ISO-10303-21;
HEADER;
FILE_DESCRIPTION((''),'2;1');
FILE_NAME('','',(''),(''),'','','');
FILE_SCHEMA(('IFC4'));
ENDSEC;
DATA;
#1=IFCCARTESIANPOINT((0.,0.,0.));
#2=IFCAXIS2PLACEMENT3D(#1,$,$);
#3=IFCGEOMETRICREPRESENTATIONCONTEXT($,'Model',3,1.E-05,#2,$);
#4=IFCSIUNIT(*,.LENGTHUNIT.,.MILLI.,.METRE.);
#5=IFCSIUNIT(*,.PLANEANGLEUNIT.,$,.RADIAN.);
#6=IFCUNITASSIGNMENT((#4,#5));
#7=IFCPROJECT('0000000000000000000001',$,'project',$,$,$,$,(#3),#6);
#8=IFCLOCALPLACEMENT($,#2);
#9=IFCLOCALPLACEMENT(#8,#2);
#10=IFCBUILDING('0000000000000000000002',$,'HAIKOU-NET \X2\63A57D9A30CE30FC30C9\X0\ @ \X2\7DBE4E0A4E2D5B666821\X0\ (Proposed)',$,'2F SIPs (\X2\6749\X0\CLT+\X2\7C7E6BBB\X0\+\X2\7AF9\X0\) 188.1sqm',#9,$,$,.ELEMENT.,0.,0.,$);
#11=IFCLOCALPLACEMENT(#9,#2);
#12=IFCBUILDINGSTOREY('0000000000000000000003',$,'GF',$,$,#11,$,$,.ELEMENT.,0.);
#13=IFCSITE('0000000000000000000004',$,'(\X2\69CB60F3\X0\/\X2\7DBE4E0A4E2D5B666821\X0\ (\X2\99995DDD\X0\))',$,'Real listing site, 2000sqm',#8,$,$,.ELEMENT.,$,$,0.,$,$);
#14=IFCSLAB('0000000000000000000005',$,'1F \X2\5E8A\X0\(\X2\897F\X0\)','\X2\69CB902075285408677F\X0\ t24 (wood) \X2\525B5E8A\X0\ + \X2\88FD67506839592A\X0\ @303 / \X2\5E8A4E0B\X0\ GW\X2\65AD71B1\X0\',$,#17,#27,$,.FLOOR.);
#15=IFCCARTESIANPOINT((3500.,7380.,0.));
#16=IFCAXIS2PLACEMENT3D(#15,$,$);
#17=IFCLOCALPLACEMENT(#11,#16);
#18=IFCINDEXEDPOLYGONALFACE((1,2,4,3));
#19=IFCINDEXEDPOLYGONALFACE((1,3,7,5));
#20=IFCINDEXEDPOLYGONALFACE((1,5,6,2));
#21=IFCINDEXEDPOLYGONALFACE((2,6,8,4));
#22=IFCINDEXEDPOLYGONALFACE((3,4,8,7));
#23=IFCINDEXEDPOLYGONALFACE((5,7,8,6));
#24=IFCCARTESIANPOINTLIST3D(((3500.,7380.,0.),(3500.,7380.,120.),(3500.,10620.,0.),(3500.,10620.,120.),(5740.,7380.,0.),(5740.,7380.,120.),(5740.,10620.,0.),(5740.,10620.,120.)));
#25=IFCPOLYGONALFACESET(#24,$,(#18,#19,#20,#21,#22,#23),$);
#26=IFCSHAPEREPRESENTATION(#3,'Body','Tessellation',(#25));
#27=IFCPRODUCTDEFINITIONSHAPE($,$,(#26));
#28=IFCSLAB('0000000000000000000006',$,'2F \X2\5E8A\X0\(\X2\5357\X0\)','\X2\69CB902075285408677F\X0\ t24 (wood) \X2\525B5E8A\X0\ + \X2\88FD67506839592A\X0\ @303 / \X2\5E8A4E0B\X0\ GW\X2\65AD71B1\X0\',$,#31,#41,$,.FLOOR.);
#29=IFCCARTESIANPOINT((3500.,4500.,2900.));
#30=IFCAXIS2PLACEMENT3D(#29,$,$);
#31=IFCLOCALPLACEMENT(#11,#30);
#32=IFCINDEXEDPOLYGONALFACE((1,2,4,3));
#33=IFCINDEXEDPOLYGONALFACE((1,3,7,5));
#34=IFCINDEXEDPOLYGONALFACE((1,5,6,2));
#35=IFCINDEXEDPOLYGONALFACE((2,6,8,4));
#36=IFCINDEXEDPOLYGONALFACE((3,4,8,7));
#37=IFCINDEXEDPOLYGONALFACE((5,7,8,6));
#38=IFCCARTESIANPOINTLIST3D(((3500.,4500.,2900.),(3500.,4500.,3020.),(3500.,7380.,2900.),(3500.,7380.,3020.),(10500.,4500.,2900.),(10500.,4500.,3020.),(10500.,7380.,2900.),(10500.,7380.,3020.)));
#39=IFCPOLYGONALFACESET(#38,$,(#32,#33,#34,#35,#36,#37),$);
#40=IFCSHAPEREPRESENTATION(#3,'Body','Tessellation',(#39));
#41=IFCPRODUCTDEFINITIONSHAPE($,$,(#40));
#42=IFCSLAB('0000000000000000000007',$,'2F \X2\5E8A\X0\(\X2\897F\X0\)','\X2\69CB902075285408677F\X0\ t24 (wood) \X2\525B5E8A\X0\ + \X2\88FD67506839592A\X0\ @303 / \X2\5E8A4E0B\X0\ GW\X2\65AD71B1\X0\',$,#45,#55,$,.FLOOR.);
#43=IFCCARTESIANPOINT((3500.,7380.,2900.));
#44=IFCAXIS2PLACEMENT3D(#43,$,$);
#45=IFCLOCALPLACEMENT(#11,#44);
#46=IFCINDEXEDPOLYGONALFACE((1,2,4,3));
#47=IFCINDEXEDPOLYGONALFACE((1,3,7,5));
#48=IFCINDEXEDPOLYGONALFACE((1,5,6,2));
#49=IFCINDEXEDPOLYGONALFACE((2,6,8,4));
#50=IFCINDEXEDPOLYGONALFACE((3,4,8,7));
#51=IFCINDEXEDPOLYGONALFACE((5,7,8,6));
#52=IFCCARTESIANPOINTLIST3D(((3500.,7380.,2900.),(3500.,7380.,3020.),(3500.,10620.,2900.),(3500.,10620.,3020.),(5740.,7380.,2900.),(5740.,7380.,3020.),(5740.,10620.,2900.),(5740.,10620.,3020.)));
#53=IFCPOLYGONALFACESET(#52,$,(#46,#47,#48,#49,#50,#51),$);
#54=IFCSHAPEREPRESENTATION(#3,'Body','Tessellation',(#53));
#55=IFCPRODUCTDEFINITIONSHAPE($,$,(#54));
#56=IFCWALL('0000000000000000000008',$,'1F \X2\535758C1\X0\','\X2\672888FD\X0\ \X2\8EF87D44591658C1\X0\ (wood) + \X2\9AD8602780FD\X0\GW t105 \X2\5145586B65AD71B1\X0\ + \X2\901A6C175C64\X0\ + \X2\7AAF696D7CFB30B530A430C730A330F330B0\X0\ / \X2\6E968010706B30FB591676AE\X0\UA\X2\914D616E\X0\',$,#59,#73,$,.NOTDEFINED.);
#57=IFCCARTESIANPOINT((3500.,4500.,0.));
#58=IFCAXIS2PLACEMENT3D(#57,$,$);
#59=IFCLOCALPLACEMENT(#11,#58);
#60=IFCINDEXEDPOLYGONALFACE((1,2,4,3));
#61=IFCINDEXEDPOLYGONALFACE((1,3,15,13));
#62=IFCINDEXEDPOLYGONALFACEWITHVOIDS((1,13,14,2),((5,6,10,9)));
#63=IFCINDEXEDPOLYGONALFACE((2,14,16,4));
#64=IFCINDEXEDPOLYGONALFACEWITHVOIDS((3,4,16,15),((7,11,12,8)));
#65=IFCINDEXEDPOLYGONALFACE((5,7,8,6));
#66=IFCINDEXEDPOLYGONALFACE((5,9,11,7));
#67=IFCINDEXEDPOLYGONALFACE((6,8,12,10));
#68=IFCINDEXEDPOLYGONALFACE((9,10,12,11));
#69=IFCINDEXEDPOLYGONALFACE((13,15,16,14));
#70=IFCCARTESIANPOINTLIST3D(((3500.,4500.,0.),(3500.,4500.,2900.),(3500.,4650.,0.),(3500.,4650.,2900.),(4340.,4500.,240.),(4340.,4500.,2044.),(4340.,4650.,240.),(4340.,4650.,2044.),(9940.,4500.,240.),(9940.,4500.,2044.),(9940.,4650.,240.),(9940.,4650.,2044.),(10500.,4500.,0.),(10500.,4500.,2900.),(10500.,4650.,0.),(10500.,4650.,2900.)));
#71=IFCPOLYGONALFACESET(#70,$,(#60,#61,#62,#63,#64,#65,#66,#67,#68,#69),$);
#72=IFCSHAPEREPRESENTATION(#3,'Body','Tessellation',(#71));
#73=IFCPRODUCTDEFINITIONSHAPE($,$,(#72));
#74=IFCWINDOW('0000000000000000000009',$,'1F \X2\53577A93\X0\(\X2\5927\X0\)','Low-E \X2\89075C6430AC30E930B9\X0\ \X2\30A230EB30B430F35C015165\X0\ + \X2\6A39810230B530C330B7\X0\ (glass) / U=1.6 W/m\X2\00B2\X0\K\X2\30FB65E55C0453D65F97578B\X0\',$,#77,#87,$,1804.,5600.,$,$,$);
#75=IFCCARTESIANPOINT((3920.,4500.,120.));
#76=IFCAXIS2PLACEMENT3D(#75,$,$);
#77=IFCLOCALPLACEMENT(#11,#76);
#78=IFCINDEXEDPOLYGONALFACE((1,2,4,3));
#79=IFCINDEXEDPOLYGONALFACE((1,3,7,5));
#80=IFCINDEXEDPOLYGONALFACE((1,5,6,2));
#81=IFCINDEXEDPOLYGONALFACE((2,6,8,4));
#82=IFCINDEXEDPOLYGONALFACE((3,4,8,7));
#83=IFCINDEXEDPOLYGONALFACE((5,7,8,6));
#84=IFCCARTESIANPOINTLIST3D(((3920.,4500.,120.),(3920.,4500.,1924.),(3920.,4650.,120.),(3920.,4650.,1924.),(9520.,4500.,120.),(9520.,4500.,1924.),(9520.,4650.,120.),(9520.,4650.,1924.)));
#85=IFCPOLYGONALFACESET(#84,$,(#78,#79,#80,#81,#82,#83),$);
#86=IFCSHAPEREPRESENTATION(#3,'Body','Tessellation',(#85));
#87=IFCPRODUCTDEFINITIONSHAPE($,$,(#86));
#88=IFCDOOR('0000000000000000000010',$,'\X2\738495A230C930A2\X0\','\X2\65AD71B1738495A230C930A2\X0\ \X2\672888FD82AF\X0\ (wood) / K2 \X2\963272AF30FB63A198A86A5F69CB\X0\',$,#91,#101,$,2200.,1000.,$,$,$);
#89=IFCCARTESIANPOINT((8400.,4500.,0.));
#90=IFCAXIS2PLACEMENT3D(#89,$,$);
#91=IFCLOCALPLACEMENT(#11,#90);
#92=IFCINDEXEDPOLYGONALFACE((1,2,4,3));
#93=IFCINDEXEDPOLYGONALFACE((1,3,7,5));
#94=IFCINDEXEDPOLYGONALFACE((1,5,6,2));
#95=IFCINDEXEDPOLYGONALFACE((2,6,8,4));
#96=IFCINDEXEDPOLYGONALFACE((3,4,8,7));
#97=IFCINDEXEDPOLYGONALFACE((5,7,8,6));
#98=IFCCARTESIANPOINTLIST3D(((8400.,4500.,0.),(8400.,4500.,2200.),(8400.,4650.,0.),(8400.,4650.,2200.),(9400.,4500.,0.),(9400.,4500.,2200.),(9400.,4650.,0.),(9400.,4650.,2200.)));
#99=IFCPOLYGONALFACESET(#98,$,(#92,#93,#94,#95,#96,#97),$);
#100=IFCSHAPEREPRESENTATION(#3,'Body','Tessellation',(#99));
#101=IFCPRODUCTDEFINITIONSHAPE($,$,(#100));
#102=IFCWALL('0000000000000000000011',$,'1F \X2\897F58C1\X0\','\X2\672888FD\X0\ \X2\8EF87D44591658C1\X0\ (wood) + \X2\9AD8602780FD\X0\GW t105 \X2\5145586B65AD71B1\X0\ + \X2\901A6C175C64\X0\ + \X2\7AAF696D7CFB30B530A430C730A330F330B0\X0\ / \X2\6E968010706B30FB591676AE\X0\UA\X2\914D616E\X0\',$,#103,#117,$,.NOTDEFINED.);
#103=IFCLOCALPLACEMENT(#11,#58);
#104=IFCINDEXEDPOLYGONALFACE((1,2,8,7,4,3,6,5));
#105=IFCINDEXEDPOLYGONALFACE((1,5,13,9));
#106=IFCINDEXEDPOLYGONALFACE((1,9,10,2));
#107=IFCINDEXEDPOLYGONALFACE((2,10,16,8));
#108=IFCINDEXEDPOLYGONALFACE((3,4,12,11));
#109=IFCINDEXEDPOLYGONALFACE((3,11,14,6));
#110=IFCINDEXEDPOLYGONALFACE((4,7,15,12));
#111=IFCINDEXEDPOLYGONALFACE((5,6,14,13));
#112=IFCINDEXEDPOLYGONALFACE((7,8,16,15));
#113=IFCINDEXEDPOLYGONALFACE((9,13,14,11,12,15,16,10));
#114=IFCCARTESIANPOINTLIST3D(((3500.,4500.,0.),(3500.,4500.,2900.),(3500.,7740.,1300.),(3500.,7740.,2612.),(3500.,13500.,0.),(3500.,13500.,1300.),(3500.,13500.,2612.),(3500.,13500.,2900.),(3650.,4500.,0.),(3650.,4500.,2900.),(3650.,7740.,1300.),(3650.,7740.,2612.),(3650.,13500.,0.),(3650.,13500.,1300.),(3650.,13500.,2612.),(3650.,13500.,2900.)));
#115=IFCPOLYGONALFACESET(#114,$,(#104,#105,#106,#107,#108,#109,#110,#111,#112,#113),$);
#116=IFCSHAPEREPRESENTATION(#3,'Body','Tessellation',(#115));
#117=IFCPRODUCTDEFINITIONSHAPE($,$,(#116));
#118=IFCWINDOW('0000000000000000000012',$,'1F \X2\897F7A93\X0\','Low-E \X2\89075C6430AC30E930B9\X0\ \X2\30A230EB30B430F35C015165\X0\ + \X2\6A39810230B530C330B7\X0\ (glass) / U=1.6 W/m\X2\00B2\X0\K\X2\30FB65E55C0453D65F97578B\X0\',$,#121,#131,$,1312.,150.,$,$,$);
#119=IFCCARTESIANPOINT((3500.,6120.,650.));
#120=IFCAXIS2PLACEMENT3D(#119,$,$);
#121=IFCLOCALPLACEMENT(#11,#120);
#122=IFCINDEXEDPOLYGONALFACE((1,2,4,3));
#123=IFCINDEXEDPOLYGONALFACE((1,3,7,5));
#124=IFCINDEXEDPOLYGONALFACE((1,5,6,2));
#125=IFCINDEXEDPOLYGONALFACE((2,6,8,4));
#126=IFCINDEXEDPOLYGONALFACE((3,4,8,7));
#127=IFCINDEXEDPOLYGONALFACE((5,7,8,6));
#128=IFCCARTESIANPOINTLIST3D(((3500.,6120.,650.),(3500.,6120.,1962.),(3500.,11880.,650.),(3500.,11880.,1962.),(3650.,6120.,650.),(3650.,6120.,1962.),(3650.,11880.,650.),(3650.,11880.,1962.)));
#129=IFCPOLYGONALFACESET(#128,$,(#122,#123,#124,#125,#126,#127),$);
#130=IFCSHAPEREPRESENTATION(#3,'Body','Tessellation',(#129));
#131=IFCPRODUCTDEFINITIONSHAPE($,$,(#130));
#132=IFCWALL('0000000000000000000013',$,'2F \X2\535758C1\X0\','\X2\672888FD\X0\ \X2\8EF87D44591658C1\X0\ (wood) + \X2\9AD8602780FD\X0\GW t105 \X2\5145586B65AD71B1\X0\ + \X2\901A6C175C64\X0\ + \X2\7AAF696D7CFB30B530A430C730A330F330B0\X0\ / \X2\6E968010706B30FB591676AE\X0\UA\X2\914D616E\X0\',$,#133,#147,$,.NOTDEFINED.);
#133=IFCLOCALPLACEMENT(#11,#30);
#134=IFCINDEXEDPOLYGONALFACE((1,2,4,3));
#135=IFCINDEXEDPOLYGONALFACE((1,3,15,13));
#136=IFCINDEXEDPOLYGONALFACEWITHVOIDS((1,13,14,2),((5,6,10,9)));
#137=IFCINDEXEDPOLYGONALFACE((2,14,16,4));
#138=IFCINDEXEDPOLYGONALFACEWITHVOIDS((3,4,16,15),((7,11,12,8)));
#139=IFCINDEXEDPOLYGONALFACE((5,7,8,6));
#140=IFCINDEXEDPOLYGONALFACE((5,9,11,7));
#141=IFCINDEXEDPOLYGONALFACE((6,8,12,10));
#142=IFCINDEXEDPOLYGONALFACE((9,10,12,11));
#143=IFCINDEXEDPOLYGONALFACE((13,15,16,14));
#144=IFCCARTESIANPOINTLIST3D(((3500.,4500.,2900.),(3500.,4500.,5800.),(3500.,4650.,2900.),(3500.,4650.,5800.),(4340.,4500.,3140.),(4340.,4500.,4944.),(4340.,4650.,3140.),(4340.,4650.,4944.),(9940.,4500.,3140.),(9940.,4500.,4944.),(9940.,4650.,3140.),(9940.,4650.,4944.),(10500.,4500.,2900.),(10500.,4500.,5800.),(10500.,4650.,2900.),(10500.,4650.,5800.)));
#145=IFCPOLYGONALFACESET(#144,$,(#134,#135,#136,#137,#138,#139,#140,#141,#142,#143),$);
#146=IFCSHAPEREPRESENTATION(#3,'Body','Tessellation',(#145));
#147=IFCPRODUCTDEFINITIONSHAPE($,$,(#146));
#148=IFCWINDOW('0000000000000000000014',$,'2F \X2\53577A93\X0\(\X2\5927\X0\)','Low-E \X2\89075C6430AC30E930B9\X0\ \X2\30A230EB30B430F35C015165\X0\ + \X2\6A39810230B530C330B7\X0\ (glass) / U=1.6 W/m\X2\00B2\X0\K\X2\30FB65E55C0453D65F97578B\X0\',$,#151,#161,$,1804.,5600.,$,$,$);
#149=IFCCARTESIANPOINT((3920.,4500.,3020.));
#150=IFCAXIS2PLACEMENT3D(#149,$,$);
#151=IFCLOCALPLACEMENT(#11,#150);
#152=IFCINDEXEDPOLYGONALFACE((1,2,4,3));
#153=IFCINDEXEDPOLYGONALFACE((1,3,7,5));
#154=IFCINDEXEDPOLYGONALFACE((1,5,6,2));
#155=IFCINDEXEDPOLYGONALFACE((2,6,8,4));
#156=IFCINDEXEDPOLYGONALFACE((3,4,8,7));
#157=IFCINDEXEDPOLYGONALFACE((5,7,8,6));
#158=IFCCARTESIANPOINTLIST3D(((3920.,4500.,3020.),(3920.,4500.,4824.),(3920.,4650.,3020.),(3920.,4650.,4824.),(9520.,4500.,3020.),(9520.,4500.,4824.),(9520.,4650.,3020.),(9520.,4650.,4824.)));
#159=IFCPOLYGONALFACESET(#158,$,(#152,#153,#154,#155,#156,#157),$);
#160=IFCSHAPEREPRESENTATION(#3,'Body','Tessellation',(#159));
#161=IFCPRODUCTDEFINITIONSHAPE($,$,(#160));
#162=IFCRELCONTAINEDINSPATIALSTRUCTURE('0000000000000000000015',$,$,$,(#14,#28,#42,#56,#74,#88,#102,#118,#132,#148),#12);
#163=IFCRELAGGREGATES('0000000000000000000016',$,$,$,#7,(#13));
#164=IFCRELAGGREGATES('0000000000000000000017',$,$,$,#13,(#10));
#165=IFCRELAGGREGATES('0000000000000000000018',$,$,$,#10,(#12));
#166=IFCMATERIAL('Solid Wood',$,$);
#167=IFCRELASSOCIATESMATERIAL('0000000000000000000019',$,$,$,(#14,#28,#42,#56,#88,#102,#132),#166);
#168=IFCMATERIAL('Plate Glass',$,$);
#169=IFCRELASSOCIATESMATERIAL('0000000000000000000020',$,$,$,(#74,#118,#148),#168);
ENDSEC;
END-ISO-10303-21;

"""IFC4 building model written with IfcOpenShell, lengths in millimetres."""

from ifc_helpers import new_model, si_unit, frame, frame_2d, origin, place, context, project, spatial, rectangle, extrude, material, element, fill, save


model = new_model("IFC4")

# Units and contexts
model_context = context("Model", 3, precision=1e-05, world=origin())
ifc_project = project(units=[si_unit("LENGTHUNIT", "METRE", prefix="MILLI"), si_unit("PLANEANGLEUNIT", "RADIAN")], contexts=[model_context])

# Site, building, storey
site_placement = place(None, origin())
site = spatial("IfcSite", under=ifc_project, at=site_placement, Name="(構想/綾上中学校 (香川))", ObjectType="Real listing site, 2000sqm", CompositionType="ELEMENT", RefElevation=0.0)
building_placement = place(site_placement, origin())
building = spatial("IfcBuilding", under=site, at=building_placement, Name="HAIKOU-NET 接続ノード @ 綾上中学校 (Proposed)", ObjectType="2F SIPs (杉CLT+籾殻+竹) 188.1sqm", CompositionType="ELEMENT", ElevationOfRefHeight=0.0, ElevationOfTerrain=0.0)
storey_placement = place(building_placement, origin())
storey = spatial("IfcBuildingStorey", under=building, at=storey_placement, Name="GF", CompositionType="ELEMENT", Elevation=0.0)

# Slabs
ifc_material_1 = material(Name="Solid Wood")
slab_1_placement = place(storey_placement, frame((3500.0, 7380.0, 0.0)))
element("IfcSlab", 1, at=slab_1_placement, inside=storey, material=ifc_material_1, Name="1F 床(西)", Description="構造用合板 t24 (wood) 剛床 + 製材根太 @303 / 床下 GW断熱", PredefinedType="FLOOR", context=model_context, shape_type="SweptSolid", body=[
    extrude(rectangle(XDim=2240.0, YDim=3240.0, at=frame_2d((1120.0, 1620.0))), frame((3500.0, 7380.0, 0.0)), (0.0, 0.0, 1.0), 120.0),
])
slab_2_placement = place(storey_placement, frame((3500.0, 4500.0, 2900.0)))
element("IfcSlab", 2, at=slab_2_placement, inside=storey, material=ifc_material_1, Name="2F 床(南)", Description="構造用合板 t24 (wood) 剛床 + 製材根太 @303 / 床下 GW断熱", PredefinedType="FLOOR", context=model_context, shape_type="SweptSolid", body=[
    extrude(rectangle(XDim=7000.0, YDim=2880.0, at=frame_2d((3500.0, 1440.0))), frame((3500.0, 4500.0, 2900.0)), (0.0, 0.0, 1.0), 120.0),
])
slab_3_placement = place(storey_placement, frame((3500.0, 7380.0, 2900.0)))
element("IfcSlab", 3, at=slab_3_placement, inside=storey, material=ifc_material_1, Name="2F 床(西)", Description="構造用合板 t24 (wood) 剛床 + 製材根太 @303 / 床下 GW断熱", PredefinedType="FLOOR", context=model_context, shape_type="SweptSolid", body=[
    extrude(rectangle(XDim=2240.0, YDim=3240.0, at=frame_2d((1120.0, 1620.0))), frame((3500.0, 7380.0, 2900.0)), (0.0, 0.0, 1.0), 120.0),
])

# Wall, openings, window, door
wall_1_placement = place(storey_placement, frame((3500.0, 4500.0, 0.0)))
wall_1 = element("IfcWall", 4, at=wall_1_placement, inside=storey, material=ifc_material_1, Name="1F 南壁", Description="木製 軸組外壁 (wood) + 高性能GW t105 充填断熱 + 通気層 + 窯業系サイディング / 準耐火・外皮UA配慮", PredefinedType="NOTDEFINED", context=model_context, shape_type="SweptSolid", body=[
    extrude(rectangle(XDim=7000.0, YDim=150.0, at=frame_2d((3500.0, 75.0))), frame((3500.0, 4500.0, 0.0)), (0.0, 0.0, 1.0), 2900.0),
])
opening_1_placement = place(storey_placement, frame((3920.0, 4500.0, 120.0)))
opening_1 = element("IfcOpeningElement", 5, at=opening_1_placement, cuts=wall_1, PredefinedType="NOTDEFINED", context=model_context, shape_type="SweptSolid", body=[
    extrude(rectangle(XDim=5600.0, YDim=150.0, at=frame_2d((2800.0, 75.0))), frame((3920.0, 4500.0, 120.0)), (0.0, 0.0, 1.0), 1804.0),
])
opening_2_placement = place(storey_placement, frame((8400.0, 4500.0, 0.0)))
opening_2 = element("IfcOpeningElement", 6, at=opening_2_placement, cuts=wall_1, PredefinedType="NOTDEFINED", context=model_context, shape_type="SweptSolid", body=[
    extrude(rectangle(XDim=1000.0, YDim=150.0, at=frame_2d((500.0, 75.0))), frame((8400.0, 4500.0, 0.0)), (0.0, 0.0, 1.0), 2200.0),
])
ifc_material_2 = material(Name="Plate Glass")
window_1_placement = place(storey_placement, frame((3920.0, 4500.0, 120.0)))
window_1 = element("IfcWindow", 7, at=window_1_placement, inside=storey, material=ifc_material_2, Name="1F 南窓(大)", Description="Low-E 複層ガラス アルゴン封入 + 樹脂サッシ (glass) / U=1.6 W/m²K・日射取得型", OverallHeight=1804.0, OverallWidth=5600.0, context=model_context, shape_type="SweptSolid", body=[
    extrude(rectangle(XDim=5600.0, YDim=150.0, at=frame_2d((2800.0, 75.0))), frame((3920.0, 4500.0, 120.0)), (0.0, 0.0, 1.0), 1804.0),
])
fill(opening_1, window_1)
door_placement = place(storey_placement, frame((8400.0, 4500.0, 0.0)))
door = element("IfcDoor", 8, at=door_placement, inside=storey, material=ifc_material_1, Name="玄関ドア", Description="断熱玄関ドア 木製芯 (wood) / K2 防犯・採風機構", OverallHeight=2200.0, OverallWidth=1000.0, context=model_context, shape_type="SweptSolid", body=[
    extrude(rectangle(XDim=1000.0, YDim=150.0, at=frame_2d((500.0, 75.0))), frame((8400.0, 4500.0, 0.0)), (0.0, 0.0, 1.0), 2200.0),
])
fill(opening_2, door)

# Walls, openings, windows
wall_2_placement = place(storey_placement, frame((3500.0, 4500.0, 0.0)))
wall_2 = element("IfcWall", 9, at=wall_2_placement, inside=storey, material=ifc_material_1, Name="1F 西壁", Description="木製 軸組外壁 (wood) + 高性能GW t105 充填断熱 + 通気層 + 窯業系サイディング / 準耐火・外皮UA配慮", PredefinedType="NOTDEFINED", context=model_context, shape_type="SweptSolid", body=[
    extrude(rectangle(XDim=150.0, YDim=9000.0, at=frame_2d((75.0, 4500.0))), frame((3500.0, 4500.0, 0.0)), (0.0, 0.0, 1.0), 2900.0),
])
opening_3_placement = place(storey_placement, frame((3500.0, 6120.0, 650.0)))
opening_3 = element("IfcOpeningElement", 10, at=opening_3_placement, cuts=wall_2, PredefinedType="NOTDEFINED", context=model_context, shape_type="SweptSolid", body=[
    extrude(rectangle(XDim=150.0, YDim=5760.0, at=frame_2d((75.0, 2880.0))), frame((3500.0, 6120.0, 650.0)), (0.0, 0.0, 1.0), 1312.0),
])
window_2_placement = place(storey_placement, frame((3500.0, 6120.0, 650.0)))
window_2 = element("IfcWindow", 11, at=window_2_placement, inside=storey, material=ifc_material_2, Name="1F 西窓", Description="Low-E 複層ガラス アルゴン封入 + 樹脂サッシ (glass) / U=1.6 W/m²K・日射取得型", OverallHeight=1312.0, OverallWidth=150.0, context=model_context, shape_type="SweptSolid", body=[
    extrude(rectangle(XDim=150.0, YDim=5760.0, at=frame_2d((75.0, 2880.0))), frame((3500.0, 6120.0, 650.0)), (0.0, 0.0, 1.0), 1312.0),
])
fill(opening_3, window_2)
wall_3_placement = place(storey_placement, frame((3500.0, 4500.0, 2900.0)))
wall_3 = element("IfcWall", 12, at=wall_3_placement, inside=storey, material=ifc_material_1, Name="2F 南壁", Description="木製 軸組外壁 (wood) + 高性能GW t105 充填断熱 + 通気層 + 窯業系サイディング / 準耐火・外皮UA配慮", PredefinedType="NOTDEFINED", context=model_context, shape_type="SweptSolid", body=[
    extrude(rectangle(XDim=7000.0, YDim=150.0, at=frame_2d((3500.0, 75.0))), frame((3500.0, 4500.0, 2900.0)), (0.0, 0.0, 1.0), 2900.0),
])
opening_4_placement = place(storey_placement, frame((3920.0, 4500.0, 3020.0)))
opening_4 = element("IfcOpeningElement", 13, at=opening_4_placement, cuts=wall_3, PredefinedType="NOTDEFINED", context=model_context, shape_type="SweptSolid", body=[
    extrude(rectangle(XDim=5600.0, YDim=150.0, at=frame_2d((2800.0, 75.0))), frame((3920.0, 4500.0, 3020.0)), (0.0, 0.0, 1.0), 1804.0),
])
window_3_placement = place(storey_placement, frame((3920.0, 4500.0, 3020.0)))
window_3 = element("IfcWindow", 14, at=window_3_placement, inside=storey, material=ifc_material_2, Name="2F 南窓(大)", Description="Low-E 複層ガラス アルゴン封入 + 樹脂サッシ (glass) / U=1.6 W/m²K・日射取得型", OverallHeight=1804.0, OverallWidth=5600.0, context=model_context, shape_type="SweptSolid", body=[
    extrude(rectangle(XDim=5600.0, YDim=150.0, at=frame_2d((2800.0, 75.0))), frame((3920.0, 4500.0, 3020.0)), (0.0, 0.0, 1.0), 1804.0),
])
fill(opening_4, window_3)

save(model, "model.ifc")
